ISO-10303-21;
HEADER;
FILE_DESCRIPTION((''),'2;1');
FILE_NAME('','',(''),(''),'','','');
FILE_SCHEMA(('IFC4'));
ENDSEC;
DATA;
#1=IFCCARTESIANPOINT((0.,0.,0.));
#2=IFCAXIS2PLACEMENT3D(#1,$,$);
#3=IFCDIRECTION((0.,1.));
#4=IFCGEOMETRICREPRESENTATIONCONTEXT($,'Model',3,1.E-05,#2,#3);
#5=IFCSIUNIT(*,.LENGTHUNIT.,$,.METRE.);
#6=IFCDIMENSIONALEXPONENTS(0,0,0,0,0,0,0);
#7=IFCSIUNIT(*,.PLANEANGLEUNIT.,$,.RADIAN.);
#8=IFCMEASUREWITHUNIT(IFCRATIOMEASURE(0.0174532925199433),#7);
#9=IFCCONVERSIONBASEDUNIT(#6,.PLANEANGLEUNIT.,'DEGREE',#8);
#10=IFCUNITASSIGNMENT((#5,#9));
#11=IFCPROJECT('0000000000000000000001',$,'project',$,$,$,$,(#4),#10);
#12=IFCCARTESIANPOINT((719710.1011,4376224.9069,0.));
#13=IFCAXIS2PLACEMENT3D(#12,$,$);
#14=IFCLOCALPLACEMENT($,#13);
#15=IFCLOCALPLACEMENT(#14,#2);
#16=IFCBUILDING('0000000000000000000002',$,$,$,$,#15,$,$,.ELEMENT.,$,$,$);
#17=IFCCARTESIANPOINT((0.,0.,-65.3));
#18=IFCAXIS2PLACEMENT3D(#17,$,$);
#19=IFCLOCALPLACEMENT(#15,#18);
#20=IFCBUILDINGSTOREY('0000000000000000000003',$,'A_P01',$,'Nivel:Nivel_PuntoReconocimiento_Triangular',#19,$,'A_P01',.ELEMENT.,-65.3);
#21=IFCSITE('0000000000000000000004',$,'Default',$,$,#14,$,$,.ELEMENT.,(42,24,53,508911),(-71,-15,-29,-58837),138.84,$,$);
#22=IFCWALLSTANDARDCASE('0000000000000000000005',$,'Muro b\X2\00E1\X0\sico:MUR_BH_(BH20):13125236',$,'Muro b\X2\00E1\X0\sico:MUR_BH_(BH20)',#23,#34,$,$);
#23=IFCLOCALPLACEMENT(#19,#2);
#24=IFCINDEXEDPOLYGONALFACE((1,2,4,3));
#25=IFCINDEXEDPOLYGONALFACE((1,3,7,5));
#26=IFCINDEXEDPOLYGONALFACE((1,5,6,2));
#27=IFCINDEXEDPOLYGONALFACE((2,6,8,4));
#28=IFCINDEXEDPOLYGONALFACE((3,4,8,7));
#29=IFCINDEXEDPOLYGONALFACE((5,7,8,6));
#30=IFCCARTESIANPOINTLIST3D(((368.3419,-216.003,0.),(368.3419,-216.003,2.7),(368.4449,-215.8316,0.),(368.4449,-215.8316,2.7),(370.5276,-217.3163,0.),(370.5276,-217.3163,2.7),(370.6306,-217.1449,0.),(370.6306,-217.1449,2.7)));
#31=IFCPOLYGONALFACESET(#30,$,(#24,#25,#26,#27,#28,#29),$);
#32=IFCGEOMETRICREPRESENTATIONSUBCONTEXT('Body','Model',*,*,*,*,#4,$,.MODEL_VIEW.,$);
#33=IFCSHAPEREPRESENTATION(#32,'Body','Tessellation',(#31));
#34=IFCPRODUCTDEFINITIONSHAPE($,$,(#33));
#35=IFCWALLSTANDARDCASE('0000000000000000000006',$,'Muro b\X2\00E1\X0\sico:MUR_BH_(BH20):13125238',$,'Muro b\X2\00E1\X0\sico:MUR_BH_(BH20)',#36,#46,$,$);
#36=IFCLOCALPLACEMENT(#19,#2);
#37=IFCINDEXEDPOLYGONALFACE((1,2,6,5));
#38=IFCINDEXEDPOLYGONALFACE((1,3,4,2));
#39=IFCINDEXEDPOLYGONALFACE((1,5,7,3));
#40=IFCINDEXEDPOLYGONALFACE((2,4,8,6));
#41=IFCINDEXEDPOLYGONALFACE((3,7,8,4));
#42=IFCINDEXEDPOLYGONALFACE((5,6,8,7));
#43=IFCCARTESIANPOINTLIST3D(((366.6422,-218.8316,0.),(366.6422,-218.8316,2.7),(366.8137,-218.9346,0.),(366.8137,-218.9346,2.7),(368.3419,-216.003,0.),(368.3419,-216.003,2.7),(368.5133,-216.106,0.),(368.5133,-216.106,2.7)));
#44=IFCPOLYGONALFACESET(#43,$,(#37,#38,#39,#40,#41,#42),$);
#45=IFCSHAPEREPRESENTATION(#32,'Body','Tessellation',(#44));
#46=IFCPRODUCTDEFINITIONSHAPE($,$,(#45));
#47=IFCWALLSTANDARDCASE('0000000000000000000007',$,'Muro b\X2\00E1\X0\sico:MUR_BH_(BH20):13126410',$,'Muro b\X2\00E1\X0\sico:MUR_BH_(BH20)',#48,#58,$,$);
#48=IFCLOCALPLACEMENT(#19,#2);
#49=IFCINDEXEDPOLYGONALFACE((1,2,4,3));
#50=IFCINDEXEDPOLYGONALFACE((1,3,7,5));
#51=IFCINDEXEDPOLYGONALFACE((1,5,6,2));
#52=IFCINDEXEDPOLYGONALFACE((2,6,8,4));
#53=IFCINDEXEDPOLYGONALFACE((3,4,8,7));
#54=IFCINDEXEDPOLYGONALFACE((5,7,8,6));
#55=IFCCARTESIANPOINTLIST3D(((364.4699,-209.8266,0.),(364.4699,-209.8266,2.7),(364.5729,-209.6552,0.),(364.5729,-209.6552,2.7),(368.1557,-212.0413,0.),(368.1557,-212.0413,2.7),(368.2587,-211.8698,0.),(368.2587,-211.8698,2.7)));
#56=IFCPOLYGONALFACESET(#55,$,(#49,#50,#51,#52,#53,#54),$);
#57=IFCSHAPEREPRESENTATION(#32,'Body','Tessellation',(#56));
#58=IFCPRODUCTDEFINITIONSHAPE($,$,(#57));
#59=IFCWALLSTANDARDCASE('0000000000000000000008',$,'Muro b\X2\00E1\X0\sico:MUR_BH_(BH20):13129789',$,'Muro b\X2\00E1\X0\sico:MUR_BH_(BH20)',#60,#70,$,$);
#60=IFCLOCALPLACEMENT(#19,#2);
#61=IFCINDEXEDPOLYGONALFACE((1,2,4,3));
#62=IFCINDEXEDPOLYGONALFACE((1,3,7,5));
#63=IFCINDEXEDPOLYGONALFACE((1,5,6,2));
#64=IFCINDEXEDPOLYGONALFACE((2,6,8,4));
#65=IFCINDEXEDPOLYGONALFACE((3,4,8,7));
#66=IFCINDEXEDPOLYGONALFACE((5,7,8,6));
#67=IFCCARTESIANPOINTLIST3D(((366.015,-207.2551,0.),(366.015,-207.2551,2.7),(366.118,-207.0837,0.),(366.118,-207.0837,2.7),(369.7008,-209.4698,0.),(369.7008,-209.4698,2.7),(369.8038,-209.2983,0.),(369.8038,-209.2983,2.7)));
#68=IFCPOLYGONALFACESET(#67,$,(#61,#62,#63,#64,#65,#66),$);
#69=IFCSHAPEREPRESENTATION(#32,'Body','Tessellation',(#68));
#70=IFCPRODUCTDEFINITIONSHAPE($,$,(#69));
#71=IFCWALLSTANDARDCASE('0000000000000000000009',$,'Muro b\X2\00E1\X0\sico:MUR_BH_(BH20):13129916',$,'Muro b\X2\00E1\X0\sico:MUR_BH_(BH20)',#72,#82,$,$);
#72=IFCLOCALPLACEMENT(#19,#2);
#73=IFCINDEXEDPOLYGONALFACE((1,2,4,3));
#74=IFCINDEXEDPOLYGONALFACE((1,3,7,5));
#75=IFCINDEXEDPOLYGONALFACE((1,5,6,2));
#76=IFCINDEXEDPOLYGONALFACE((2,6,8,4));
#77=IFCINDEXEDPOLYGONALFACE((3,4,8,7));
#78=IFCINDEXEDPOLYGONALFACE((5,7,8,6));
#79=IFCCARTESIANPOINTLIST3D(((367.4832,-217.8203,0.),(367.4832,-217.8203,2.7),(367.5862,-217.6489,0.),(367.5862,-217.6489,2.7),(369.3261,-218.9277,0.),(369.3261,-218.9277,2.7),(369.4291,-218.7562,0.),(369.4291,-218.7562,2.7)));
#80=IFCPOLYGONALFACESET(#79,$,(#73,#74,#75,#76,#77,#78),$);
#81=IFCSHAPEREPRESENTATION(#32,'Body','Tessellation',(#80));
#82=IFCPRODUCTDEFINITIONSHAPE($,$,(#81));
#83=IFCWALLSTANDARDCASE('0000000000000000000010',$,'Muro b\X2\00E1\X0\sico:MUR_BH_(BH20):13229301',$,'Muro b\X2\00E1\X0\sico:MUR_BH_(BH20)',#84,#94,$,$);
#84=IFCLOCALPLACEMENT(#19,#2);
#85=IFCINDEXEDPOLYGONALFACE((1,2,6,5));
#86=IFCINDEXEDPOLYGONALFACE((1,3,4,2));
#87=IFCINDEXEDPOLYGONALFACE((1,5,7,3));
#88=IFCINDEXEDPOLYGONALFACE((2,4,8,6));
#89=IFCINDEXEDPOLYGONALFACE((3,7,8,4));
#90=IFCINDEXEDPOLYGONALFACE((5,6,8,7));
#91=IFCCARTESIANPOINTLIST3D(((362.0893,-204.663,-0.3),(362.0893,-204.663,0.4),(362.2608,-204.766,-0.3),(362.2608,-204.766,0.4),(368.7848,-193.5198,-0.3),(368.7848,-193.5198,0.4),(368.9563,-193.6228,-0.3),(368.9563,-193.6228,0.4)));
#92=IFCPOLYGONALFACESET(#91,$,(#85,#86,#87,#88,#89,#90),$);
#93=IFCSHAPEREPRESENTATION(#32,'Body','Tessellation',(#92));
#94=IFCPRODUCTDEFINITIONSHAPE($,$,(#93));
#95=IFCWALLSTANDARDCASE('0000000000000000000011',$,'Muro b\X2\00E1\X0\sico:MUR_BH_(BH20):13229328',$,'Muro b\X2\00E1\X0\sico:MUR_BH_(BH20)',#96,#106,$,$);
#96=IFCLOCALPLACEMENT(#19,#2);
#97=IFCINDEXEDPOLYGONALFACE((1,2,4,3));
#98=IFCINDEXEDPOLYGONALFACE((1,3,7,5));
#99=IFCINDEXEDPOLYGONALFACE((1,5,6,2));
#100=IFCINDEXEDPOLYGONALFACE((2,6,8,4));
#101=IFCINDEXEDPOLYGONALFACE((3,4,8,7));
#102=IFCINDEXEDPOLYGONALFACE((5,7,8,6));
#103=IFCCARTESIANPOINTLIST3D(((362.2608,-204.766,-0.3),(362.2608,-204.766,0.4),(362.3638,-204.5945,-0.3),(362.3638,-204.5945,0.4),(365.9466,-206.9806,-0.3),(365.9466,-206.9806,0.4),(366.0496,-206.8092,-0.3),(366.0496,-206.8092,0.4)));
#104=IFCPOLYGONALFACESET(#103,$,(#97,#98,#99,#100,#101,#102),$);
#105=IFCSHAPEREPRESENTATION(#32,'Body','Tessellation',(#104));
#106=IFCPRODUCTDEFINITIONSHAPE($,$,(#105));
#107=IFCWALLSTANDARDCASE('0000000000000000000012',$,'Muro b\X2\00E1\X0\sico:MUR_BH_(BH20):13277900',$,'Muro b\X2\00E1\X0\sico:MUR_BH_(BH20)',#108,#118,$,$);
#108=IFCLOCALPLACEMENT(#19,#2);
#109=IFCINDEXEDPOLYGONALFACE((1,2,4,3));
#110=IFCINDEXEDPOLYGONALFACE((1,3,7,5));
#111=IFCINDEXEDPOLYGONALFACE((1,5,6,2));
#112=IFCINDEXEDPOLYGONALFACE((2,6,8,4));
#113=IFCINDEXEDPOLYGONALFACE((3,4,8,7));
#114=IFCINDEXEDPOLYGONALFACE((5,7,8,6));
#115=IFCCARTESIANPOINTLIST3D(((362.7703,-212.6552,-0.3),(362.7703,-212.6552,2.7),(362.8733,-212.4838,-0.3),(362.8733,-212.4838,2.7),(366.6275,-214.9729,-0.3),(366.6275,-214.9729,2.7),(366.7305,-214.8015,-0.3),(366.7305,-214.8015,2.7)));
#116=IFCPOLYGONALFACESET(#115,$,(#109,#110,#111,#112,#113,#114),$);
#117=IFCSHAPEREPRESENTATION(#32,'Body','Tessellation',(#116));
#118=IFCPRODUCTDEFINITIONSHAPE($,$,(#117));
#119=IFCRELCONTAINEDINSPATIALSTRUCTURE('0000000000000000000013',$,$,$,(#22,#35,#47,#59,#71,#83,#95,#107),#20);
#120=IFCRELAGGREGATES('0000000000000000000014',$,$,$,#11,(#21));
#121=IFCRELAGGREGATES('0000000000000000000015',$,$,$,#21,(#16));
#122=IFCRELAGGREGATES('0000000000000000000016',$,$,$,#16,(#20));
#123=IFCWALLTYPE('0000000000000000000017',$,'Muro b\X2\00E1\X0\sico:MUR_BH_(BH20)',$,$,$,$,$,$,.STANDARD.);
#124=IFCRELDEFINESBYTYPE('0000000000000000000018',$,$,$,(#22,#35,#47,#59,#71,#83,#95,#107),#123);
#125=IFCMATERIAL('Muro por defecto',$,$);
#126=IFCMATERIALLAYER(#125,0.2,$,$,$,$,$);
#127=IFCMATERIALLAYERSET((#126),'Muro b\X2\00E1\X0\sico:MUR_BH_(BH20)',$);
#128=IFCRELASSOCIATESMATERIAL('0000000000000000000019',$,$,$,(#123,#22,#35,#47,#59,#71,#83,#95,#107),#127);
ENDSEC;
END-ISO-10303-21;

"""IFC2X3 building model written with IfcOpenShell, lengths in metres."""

from ifc_helpers import new_model, entity, si_unit, converted_unit, direction, frame, frame_2d, origin, place, context, subcontext, project, spatial, rectangle, extrude, material, layer, layer_set, layer_usage, type_object, element, save


model = new_model("IFC2X3")

# Units and contexts
model_context = context("Model", 3, precision=1e-05, world=origin(), true_north=direction((0.0, 1.0)))
body_context = subcontext(model_context, "Body", "Model", "MODEL_VIEW")
ifc_project = project(units=[si_unit("LENGTHUNIT", "METRE"), converted_unit("PLANEANGLEUNIT", "DEGREE", entity("IfcRatioMeasure", 0.0174532925199433), si_unit("PLANEANGLEUNIT", "RADIAN"), dimensions=[0, 0, 0, 0, 0, 0, 0])], contexts=[model_context])

# Site, building, storey
site_placement = place(None, frame((719710.1011, 4376224.9069, 0.0)))
site = spatial("IfcSite", under=ifc_project, at=site_placement, Name="Default", CompositionType="ELEMENT", RefLatitude=(42, 24, 53, 508911), RefLongitude=(-71, -15, -29, -58837), RefElevation=138.84)
building_placement = place(site_placement, origin())
building = spatial("IfcBuilding", under=site, at=building_placement, CompositionType="ELEMENT")
storey_placement = place(building_placement, frame((0.0, 0.0, -65.3)))
storey = spatial("IfcBuildingStorey", under=building, at=storey_placement, Name="A_P01", ObjectType="Nivel:Nivel_PuntoReconocimiento_Triangular", LongName="A_P01", CompositionType="ELEMENT", Elevation=-65.3)

# Shared definitions
ifc_material_1 = material(Name="Muro por defecto")
ifc_layer = layer(ifc_material_1, 0.2)
ifc_layer_set = layer_set([ifc_layer], Name="Muro básico:MUR_BH_(BH20)")
wall_type = type_object("IfcWallType", Name="Muro básico:MUR_BH_(BH20)", PredefinedType="STANDARD", material=ifc_layer_set)

# Walls
ifc_layer_usage_1 = layer_usage(ifc_layer_set, "AXIS2", "NEGATIVE", 0.1)
wall_1_placement = place(storey_placement, frame((368.3934, -215.9173, 0.0), z_axis=(0.0, 0.0, 1.0), x_axis=(0.857167, -0.515038, 0.0)))
element("IfcWallStandardCase", 1, at=wall_1_placement, inside=storey, type_object=wall_type, material=ifc_layer_usage_1, Name="Muro básico:MUR_BH_(BH20):13125236", ObjectType="Muro básico:MUR_BH_(BH20)", context=body_context, shape_type="SweptSolid", body=[
    extrude(rectangle(XDim=2.55, YDim=0.2, at=frame_2d((1.275, 0.0), x_axis=(-1.0, 0.0))), origin(), (0.0, 0.0, 1.0), 2.7),
])
ifc_layer_usage_2 = layer_usage(ifc_layer_set, "AXIS2", "NEGATIVE", 0.1)
wall_2_placement = place(storey_placement, frame((368.4276, -216.0545, 0.0), z_axis=(0.0, 0.0, 1.0), x_axis=(-0.515038, -0.857167, 0.0)))
element("IfcWallStandardCase", 2, at=wall_2_placement, inside=storey, type_object=wall_type, material=ifc_layer_usage_2, Name="Muro básico:MUR_BH_(BH20):13125238", ObjectType="Muro básico:MUR_BH_(BH20)", context=body_context, shape_type="SweptSolid", body=[
    extrude(rectangle(XDim=3.3, YDim=0.2, at=frame_2d((1.65, 0.0), x_axis=(-1.0, 0.0))), origin(), (0.0, 0.0, 1.0), 2.7),
])
ifc_layer_usage_3 = layer_usage(ifc_layer_set, "AXIS2", "NEGATIVE", 0.1)
wall_3_placement = place(storey_placement, frame((368.2072, -211.9555, 0.0), z_axis=(0.0, 0.0, 1.0), x_axis=(-0.857167, 0.515038, 0.0)))
element("IfcWallStandardCase", 3, at=wall_3_placement, inside=storey, type_object=wall_type, material=ifc_layer_usage_3, Name="Muro básico:MUR_BH_(BH20):13126410", ObjectType="Muro básico:MUR_BH_(BH20)", context=body_context, shape_type="SweptSolid", body=[
    extrude(rectangle(XDim=4.3, YDim=0.2, at=frame_2d((2.15, 0.0), x_axis=(-1.0, 0.0))), origin(), (0.0, 0.0, 1.0), 2.7),
])
ifc_layer_usage_4 = layer_usage(ifc_layer_set, "AXIS2", "NEGATIVE", 0.1)
wall_4_placement = place(storey_placement, frame((369.7523, -209.384, 0.0), z_axis=(0.0, 0.0, 1.0), x_axis=(-0.857167, 0.515038, 0.0)))
element("IfcWallStandardCase", 4, at=wall_4_placement, inside=storey, type_object=wall_type, material=ifc_layer_usage_4, Name="Muro básico:MUR_BH_(BH20):13129789", ObjectType="Muro básico:MUR_BH_(BH20)", context=body_context, shape_type="SweptSolid", body=[
    extrude(rectangle(XDim=4.3, YDim=0.2, at=frame_2d((2.15, 0.0), x_axis=(-1.0, 0.0))), origin(), (0.0, 0.0, 1.0), 2.7),
])
ifc_layer_usage_5 = layer_usage(ifc_layer_set, "AXIS2", "POSITIVE", -0.1)
wall_5_placement = place(storey_placement, frame((367.5347, -217.7346, 0.0), z_axis=(0.0, 0.0, 1.0), x_axis=(0.857167, -0.515038, 0.0)))
element("IfcWallStandardCase", 5, at=wall_5_placement, inside=storey, type_object=wall_type, material=ifc_layer_usage_5, Name="Muro básico:MUR_BH_(BH20):13129916", ObjectType="Muro básico:MUR_BH_(BH20)", context=body_context, shape_type="SweptSolid", body=[
    extrude(rectangle(XDim=2.15, YDim=0.2, at=frame_2d((1.075, 0.0), x_axis=(-1.0, 0.0))), origin(), (0.0, 0.0, 1.0), 2.7),
])
ifc_layer_usage_6 = layer_usage(ifc_layer_set, "AXIS2", "POSITIVE", -0.1)
wall_6_placement = place(storey_placement, frame((368.8705, -193.5713, -0.3), z_axis=(0.0, 0.0, 1.0), x_axis=(-0.515038, -0.857167, 0.0)))
element("IfcWallStandardCase", 6, at=wall_6_placement, inside=storey, type_object=wall_type, material=ifc_layer_usage_6, Name="Muro básico:MUR_BH_(BH20):13229301", ObjectType="Muro básico:MUR_BH_(BH20)", context=body_context, shape_type="SweptSolid", body=[
    extrude(rectangle(XDim=13.0, YDim=0.2, at=frame_2d((6.5, 0.0), x_axis=(-1.0, 0.0))), origin(), (0.0, 0.0, 1.0), 0.7),
])
ifc_layer_usage_7 = layer_usage(ifc_layer_set, "AXIS2", "POSITIVE", -0.1)
wall_7_placement = place(storey_placement, frame((362.3123, -204.6803, -0.3), z_axis=(0.0, 0.0, 1.0), x_axis=(0.857167, -0.515038, 0.0)))
element("IfcWallStandardCase", 7, at=wall_7_placement, inside=storey, type_object=wall_type, material=ifc_layer_usage_7, Name="Muro básico:MUR_BH_(BH20):13229328", ObjectType="Muro básico:MUR_BH_(BH20)", context=body_context, shape_type="SweptSolid", body=[
    extrude(rectangle(XDim=4.3, YDim=0.2, at=frame_2d((2.15, 0.0), x_axis=(-1.0, 0.0))), origin(), (0.0, 0.0, 1.0), 0.7),
])
ifc_layer_usage_8 = layer_usage(ifc_layer_set, "AXIS2", "NEGATIVE", 0.1)
wall_8_placement = place(storey_placement, frame((362.8218, -212.5695, -0.3), z_axis=(0.0, 0.0, 1.0), x_axis=(0.857167, -0.515038, 0.0)))
element("IfcWallStandardCase", 8, at=wall_8_placement, inside=storey, type_object=wall_type, material=ifc_layer_usage_8, Name="Muro básico:MUR_BH_(BH20):13277900", ObjectType="Muro básico:MUR_BH_(BH20)", context=body_context, shape_type="SweptSolid", body=[
    extrude(rectangle(XDim=4.5, YDim=0.2, at=frame_2d((2.25, 0.0), x_axis=(-1.0, 0.0))), origin(), (0.0, 0.0, 1.0), 3.0),
])

save(model, "model.ifc")
